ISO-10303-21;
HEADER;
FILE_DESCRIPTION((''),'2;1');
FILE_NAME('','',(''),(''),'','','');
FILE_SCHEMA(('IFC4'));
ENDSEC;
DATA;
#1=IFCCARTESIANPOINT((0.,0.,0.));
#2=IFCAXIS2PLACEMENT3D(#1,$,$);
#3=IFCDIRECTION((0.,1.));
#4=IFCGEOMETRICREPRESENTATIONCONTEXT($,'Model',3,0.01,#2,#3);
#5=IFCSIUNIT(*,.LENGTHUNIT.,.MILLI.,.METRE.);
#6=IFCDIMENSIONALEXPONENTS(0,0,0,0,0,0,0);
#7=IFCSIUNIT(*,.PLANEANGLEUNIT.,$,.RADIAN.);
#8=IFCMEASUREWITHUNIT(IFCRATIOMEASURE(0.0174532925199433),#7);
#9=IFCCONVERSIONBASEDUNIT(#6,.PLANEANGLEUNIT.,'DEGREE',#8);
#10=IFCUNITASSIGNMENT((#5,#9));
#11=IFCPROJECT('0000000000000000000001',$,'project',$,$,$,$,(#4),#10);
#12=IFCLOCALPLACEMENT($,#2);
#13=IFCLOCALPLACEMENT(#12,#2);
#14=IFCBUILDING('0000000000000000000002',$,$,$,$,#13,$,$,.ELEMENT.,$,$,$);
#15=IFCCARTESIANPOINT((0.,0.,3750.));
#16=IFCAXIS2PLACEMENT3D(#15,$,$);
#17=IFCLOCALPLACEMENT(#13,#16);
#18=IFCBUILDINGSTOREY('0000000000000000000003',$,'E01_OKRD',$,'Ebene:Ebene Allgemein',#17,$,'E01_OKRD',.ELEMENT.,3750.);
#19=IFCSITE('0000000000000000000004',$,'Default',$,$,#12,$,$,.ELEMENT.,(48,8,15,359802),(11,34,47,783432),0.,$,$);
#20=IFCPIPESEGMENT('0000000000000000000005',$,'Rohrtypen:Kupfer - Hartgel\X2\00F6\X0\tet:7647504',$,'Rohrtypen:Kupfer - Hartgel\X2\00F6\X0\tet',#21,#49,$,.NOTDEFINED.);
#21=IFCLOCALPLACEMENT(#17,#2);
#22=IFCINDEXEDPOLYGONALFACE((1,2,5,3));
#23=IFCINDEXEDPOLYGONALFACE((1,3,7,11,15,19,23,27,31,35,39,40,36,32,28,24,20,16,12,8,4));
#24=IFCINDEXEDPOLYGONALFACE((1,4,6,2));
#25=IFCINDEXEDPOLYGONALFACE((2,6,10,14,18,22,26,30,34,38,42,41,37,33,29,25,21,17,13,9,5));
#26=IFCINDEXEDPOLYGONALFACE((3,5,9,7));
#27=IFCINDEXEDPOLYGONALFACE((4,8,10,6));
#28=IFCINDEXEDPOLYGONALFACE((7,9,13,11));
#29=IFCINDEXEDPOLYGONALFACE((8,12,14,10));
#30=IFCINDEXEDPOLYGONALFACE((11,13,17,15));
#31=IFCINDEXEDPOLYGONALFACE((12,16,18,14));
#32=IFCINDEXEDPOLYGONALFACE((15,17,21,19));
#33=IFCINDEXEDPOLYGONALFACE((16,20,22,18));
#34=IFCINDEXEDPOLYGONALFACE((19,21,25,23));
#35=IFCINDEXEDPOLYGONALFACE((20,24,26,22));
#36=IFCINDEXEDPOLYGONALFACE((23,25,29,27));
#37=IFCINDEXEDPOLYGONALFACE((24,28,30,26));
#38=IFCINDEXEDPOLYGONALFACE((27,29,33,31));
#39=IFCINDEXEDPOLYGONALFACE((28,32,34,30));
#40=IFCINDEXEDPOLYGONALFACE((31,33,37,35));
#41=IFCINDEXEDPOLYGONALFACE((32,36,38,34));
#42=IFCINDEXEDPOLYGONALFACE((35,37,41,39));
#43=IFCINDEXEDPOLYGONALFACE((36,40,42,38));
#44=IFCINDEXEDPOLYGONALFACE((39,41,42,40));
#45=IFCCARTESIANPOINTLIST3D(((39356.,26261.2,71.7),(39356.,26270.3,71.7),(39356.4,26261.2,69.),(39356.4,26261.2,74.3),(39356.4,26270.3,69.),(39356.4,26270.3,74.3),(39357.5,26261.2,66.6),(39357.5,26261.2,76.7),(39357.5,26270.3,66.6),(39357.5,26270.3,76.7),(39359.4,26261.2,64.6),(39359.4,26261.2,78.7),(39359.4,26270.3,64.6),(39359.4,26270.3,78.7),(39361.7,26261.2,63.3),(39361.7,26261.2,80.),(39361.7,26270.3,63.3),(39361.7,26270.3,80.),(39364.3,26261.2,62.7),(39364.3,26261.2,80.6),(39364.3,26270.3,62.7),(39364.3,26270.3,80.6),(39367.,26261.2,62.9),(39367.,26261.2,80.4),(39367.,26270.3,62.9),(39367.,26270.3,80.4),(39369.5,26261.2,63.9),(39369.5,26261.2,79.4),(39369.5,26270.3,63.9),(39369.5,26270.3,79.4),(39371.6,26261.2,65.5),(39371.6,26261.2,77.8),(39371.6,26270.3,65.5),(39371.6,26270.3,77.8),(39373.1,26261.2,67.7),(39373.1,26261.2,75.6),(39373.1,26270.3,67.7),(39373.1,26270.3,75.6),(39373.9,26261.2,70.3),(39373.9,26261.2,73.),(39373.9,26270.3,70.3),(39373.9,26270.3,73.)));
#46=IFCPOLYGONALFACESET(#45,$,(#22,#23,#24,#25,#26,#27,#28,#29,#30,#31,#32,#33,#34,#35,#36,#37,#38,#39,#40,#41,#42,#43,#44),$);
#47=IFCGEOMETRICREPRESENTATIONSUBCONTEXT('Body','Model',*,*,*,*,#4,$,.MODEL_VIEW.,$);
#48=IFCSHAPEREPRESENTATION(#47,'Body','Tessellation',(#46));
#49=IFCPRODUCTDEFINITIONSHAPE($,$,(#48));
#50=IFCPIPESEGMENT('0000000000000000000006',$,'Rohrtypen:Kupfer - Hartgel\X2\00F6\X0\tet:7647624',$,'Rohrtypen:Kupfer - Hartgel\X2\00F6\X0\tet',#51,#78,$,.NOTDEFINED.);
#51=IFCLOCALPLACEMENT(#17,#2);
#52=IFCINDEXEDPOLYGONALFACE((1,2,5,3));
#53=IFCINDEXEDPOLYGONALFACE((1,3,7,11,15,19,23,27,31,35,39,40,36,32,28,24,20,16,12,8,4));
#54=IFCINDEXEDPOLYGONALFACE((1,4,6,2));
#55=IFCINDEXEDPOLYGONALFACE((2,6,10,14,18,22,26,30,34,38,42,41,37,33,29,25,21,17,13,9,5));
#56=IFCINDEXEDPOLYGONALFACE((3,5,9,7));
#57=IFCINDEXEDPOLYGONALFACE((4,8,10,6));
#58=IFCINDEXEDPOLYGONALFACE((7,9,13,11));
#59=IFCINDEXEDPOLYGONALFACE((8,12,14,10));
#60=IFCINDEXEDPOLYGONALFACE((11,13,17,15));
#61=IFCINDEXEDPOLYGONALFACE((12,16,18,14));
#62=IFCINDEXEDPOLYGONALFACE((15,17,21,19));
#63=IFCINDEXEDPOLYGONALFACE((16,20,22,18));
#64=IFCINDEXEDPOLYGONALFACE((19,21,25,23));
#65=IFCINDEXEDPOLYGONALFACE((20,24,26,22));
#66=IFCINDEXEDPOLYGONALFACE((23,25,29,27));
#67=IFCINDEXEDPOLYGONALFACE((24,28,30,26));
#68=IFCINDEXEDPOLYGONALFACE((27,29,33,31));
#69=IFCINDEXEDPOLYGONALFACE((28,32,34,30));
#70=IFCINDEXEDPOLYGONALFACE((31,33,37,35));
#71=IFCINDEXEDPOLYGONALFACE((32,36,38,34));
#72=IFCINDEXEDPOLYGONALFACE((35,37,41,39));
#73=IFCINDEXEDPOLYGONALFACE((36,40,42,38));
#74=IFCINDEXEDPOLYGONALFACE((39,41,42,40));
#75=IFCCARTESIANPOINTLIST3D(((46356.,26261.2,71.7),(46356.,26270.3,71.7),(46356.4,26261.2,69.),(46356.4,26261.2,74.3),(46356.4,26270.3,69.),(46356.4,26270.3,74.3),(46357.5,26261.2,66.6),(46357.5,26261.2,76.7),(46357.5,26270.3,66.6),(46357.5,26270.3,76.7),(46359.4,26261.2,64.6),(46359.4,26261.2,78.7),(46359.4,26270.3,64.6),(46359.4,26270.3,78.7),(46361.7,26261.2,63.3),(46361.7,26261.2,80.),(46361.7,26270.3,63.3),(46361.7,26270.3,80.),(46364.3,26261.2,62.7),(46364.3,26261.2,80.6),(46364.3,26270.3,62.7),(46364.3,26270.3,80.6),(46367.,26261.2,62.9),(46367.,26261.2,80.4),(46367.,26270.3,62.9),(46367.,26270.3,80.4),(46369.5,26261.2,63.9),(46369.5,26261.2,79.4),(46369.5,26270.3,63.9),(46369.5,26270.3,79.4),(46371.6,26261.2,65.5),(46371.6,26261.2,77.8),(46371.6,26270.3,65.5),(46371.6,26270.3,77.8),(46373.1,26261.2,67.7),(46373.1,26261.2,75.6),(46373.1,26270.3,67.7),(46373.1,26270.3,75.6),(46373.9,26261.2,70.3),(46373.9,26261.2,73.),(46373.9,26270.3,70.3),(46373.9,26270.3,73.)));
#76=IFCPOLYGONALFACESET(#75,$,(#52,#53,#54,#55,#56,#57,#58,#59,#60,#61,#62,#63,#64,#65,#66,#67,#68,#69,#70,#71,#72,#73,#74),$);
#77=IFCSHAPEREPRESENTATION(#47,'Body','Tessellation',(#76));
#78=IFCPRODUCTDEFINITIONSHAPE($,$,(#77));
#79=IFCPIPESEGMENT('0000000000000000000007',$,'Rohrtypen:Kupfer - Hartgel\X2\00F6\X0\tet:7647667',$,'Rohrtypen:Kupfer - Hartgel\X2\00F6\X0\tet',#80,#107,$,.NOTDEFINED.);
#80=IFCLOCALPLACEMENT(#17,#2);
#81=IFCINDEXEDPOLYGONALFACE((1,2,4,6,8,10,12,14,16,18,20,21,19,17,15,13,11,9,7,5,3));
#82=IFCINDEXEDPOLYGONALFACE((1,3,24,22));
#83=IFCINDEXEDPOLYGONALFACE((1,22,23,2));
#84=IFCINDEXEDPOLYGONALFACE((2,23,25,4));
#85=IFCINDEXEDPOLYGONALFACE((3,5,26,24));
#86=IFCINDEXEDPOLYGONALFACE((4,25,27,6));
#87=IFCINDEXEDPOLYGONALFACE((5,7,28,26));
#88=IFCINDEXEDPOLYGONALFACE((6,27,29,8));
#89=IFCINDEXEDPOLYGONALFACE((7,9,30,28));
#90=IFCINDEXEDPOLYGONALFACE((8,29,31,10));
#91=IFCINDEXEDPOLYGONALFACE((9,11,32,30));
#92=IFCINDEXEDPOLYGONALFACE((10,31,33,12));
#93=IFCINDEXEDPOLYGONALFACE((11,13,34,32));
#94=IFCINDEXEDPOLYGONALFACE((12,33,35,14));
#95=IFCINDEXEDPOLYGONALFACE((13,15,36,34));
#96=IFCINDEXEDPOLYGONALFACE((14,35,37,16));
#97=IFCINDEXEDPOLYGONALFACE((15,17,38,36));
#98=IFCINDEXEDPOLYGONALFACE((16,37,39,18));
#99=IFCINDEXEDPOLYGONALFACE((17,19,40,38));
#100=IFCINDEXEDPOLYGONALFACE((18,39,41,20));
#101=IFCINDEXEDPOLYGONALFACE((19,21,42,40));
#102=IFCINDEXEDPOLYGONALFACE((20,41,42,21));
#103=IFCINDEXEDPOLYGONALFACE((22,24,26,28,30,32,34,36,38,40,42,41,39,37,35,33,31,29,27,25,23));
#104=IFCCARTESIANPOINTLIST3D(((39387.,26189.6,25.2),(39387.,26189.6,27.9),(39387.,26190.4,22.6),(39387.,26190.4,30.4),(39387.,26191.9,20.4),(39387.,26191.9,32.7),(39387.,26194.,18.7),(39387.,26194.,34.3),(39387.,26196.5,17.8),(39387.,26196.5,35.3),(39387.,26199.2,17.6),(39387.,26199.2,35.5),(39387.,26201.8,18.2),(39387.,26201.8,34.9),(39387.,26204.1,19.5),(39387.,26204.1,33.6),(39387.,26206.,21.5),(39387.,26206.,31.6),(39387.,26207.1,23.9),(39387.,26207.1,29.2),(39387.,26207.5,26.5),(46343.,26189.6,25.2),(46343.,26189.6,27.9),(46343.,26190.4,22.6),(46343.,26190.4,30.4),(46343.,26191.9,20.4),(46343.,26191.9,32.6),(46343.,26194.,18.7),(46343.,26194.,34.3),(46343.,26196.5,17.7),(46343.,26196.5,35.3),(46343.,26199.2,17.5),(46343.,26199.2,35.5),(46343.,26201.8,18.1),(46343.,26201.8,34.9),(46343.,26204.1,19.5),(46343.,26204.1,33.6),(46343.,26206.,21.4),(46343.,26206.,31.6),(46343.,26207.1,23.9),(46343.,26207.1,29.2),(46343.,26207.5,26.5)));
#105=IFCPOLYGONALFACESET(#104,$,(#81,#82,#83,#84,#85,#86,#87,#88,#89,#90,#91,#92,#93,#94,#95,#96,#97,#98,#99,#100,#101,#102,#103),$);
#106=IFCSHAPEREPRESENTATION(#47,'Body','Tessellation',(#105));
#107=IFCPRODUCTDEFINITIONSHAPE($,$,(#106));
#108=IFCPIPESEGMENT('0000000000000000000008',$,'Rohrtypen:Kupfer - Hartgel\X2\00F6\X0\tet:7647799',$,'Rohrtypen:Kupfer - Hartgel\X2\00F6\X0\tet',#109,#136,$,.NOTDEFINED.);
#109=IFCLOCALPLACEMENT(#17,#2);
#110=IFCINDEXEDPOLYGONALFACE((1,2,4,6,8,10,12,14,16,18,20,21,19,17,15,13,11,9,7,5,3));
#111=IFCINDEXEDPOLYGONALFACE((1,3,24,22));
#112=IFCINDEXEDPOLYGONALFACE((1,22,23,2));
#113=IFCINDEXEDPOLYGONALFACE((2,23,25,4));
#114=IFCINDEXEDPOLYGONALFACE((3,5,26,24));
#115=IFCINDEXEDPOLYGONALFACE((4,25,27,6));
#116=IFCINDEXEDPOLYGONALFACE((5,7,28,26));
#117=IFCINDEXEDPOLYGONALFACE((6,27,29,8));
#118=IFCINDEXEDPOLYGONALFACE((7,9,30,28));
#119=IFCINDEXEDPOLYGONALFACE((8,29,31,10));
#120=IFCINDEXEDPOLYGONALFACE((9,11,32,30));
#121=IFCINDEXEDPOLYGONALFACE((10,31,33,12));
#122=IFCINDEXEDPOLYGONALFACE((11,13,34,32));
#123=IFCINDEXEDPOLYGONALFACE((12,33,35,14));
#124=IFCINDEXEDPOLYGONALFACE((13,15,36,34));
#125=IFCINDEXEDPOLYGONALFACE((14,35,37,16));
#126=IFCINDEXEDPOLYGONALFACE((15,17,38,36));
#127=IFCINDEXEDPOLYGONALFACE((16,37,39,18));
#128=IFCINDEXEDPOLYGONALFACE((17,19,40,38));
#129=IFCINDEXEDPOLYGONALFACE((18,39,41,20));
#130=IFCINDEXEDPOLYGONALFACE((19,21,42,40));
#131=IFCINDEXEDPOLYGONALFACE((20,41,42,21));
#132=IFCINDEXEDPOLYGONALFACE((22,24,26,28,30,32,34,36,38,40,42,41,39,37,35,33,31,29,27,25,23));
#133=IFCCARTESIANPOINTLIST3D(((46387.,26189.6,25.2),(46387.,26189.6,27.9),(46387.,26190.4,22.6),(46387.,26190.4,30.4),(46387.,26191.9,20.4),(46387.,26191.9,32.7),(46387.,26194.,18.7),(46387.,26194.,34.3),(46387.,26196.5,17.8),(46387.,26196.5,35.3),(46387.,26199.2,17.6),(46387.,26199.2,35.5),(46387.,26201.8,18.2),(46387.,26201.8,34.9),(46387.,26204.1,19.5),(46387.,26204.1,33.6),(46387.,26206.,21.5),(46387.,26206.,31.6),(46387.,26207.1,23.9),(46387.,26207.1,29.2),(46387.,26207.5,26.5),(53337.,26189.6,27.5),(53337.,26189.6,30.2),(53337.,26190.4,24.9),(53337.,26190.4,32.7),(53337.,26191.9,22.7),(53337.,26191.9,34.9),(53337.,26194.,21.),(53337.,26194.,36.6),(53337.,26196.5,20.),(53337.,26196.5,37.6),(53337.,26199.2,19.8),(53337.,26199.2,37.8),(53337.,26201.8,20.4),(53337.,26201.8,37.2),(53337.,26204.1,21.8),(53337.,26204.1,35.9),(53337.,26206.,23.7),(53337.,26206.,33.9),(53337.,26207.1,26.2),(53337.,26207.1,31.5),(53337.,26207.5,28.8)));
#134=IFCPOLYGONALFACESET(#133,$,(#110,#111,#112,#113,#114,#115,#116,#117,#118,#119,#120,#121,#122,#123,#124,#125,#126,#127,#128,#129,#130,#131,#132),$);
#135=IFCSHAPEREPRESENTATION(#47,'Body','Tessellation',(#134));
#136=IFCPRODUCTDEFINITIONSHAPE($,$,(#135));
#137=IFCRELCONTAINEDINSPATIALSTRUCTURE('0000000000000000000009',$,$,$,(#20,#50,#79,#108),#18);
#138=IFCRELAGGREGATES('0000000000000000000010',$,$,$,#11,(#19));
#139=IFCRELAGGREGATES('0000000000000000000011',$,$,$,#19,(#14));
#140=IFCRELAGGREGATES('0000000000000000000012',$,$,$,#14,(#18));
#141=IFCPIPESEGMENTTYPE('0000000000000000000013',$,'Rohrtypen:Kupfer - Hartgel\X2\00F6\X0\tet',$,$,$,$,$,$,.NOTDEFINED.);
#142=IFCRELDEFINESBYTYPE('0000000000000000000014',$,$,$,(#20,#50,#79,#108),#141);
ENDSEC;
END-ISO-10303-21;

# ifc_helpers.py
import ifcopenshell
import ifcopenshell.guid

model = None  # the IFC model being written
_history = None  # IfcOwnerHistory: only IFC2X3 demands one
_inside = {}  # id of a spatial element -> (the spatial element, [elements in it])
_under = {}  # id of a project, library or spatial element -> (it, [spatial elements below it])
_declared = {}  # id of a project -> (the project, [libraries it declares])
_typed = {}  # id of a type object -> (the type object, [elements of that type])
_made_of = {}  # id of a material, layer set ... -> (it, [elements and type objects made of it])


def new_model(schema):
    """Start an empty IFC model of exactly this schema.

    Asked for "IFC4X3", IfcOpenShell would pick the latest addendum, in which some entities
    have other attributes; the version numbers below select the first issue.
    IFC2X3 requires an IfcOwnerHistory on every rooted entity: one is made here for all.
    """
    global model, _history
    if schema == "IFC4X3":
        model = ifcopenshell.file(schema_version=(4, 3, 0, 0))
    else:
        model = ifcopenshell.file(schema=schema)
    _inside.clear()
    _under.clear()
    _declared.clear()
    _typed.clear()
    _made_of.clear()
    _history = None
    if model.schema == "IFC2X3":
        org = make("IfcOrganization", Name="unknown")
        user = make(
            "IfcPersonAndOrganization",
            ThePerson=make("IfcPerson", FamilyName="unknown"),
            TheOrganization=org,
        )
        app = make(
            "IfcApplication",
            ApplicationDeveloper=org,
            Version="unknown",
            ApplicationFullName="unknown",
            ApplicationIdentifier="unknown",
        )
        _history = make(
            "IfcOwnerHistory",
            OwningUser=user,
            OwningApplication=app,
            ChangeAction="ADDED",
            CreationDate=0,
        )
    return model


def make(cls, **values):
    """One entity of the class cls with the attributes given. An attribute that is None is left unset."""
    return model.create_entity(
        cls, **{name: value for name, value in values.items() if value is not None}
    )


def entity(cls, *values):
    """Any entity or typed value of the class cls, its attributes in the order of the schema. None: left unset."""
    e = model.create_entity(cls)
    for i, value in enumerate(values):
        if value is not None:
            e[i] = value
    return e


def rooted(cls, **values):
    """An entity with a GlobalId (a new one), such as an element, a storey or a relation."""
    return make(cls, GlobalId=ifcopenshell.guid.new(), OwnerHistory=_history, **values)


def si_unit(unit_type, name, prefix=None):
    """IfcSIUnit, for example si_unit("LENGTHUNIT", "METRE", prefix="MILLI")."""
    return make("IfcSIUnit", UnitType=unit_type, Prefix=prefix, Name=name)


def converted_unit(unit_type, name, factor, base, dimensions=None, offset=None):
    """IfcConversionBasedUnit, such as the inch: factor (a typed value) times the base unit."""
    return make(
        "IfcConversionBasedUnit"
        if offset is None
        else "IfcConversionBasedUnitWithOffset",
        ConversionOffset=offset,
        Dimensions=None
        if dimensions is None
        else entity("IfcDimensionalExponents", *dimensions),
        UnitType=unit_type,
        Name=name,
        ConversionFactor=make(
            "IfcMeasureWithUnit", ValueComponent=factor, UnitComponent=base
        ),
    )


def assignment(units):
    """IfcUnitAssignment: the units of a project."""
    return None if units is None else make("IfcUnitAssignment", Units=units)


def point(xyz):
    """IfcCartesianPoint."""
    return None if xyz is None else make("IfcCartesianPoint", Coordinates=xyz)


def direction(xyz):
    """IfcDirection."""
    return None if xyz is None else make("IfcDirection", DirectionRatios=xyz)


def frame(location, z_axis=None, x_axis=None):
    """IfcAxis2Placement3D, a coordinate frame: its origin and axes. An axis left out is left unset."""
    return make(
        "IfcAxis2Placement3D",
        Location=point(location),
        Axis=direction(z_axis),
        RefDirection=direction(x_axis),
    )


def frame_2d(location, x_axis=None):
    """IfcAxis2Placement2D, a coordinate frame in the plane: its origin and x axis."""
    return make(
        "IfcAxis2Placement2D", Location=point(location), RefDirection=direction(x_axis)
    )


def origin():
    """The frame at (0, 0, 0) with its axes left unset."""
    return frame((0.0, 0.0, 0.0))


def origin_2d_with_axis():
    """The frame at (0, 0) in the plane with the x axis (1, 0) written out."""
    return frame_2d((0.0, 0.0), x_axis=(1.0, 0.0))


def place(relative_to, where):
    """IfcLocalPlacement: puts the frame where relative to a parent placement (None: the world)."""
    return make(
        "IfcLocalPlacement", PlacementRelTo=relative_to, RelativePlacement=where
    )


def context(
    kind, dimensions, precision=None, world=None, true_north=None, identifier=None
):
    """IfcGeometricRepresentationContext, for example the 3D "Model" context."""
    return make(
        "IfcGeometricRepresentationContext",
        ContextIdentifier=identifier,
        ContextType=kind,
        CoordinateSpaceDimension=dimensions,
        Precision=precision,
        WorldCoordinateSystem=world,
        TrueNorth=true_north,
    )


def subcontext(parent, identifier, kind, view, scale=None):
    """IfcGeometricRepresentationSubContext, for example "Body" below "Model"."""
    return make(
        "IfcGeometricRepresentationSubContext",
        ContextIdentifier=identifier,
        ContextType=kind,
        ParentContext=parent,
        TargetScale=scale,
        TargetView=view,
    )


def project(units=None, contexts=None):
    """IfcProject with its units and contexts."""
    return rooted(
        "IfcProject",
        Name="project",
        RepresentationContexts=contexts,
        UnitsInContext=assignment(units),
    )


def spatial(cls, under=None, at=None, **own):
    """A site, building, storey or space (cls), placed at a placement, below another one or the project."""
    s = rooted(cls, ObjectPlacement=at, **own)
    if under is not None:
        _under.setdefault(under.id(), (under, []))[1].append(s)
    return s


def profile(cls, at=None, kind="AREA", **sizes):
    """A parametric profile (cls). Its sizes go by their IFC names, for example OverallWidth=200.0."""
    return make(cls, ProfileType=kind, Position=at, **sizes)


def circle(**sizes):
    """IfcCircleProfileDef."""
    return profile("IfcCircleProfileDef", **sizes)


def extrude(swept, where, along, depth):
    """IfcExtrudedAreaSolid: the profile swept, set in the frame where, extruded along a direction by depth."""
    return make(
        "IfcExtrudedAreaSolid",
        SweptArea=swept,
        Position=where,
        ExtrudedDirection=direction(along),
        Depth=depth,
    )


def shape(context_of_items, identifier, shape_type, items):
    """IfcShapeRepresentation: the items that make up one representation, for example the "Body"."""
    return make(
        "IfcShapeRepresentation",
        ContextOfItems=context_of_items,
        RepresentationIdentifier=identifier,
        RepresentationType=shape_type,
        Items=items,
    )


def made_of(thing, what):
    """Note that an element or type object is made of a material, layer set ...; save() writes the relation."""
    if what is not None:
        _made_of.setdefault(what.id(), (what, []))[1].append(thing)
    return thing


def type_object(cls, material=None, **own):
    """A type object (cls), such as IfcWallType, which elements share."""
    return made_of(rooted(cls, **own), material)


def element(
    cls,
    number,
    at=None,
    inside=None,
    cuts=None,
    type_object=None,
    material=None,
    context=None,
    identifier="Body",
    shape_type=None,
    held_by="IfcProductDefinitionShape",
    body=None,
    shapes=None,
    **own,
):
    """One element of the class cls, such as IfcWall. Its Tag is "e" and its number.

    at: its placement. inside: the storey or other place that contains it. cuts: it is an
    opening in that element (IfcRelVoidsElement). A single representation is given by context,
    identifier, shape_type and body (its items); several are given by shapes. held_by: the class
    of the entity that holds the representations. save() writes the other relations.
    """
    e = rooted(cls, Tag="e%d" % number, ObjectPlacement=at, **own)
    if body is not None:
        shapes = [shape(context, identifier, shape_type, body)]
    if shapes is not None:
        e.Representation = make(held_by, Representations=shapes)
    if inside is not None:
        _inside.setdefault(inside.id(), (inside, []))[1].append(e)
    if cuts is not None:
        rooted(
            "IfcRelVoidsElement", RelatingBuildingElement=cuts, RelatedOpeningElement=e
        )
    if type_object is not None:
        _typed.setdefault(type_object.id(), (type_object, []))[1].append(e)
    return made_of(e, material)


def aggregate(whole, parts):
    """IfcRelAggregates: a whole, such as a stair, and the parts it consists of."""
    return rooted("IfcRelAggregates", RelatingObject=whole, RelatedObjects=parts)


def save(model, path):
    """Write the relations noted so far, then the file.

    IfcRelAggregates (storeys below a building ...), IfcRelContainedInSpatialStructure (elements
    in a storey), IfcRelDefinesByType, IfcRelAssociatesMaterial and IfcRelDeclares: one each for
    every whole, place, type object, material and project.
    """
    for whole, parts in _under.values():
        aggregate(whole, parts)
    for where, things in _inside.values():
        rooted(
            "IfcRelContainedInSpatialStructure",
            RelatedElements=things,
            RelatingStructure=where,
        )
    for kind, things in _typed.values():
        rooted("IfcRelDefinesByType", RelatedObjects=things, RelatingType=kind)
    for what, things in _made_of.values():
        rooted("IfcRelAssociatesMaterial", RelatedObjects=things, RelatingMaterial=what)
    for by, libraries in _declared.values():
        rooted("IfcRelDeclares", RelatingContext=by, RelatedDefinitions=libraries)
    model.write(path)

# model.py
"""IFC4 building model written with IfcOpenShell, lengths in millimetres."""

from ifc_helpers import new_model, entity, si_unit, converted_unit, direction, frame, frame_2d, origin, origin_2d_with_axis, place, context, subcontext, project, spatial, circle, extrude, type_object, element, save


model = new_model("IFC4")

# Units and contexts
model_context = context("Model", 3, precision=0.01, world=origin(), true_north=direction((0.0, 1.0)))
body_context = subcontext(model_context, "Body", "Model", "MODEL_VIEW")
ifc_project = project(units=[si_unit("LENGTHUNIT", "METRE", prefix="MILLI"), converted_unit("PLANEANGLEUNIT", "DEGREE", entity("IfcRatioMeasure", 0.0174532925199433), si_unit("PLANEANGLEUNIT", "RADIAN"), dimensions=[0, 0, 0, 0, 0, 0, 0])], contexts=[model_context])

# Site, building, storey
site_placement = place(None, origin())
site = spatial("IfcSite", under=ifc_project, at=site_placement, Name="Default", CompositionType="ELEMENT", RefLatitude=(48, 8, 15, 359802), RefLongitude=(11, 34, 47, 783432), RefElevation=0.0)
building_placement = place(site_placement, origin())
building = spatial("IfcBuilding", under=site, at=building_placement, CompositionType="ELEMENT")
storey_placement = place(building_placement, frame((0.0, 0.0, 3750.0)))
storey = spatial("IfcBuildingStorey", under=building, at=storey_placement, Name="E01_OKRD", ObjectType="Ebene:Ebene Allgemein", LongName="E01_OKRD", CompositionType="ELEMENT", Elevation=3750.0)

# Pipe segments
pipe_segment_type = type_object("IfcPipeSegmentType", Name="Rohrtypen:Kupfer - Hartgelötet", PredefinedType="NOTDEFINED")
pipe_segment_1_placement = place(storey_placement, frame((39354.4, 26261.2, 61.1)))
element("IfcPipeSegment", 1, at=pipe_segment_1_placement, inside=storey, type_object=pipe_segment_type, Name="Rohrtypen:Kupfer - Hartgelötet:7647504", ObjectType="Rohrtypen:Kupfer - Hartgelötet", PredefinedType="NOTDEFINED", context=body_context, shape_type="SweptSolid", body=[
    extrude(circle(Radius=9.0, at=frame_2d((0.0, 0.0), x_axis=(1.0, 0.0))), frame((10.6, 9.1, 10.6), z_axis=(0.000126, -1.0, -0.000366), x_axis=(-1.0, -0.000126, 0.0)), (0.0, 0.0, 1.0), 9.1),
])
pipe_segment_2_placement = place(storey_placement, frame((46354.4, 26261.2, 61.1)))
element("IfcPipeSegment", 2, at=pipe_segment_2_placement, inside=storey, type_object=pipe_segment_type, Name="Rohrtypen:Kupfer - Hartgelötet:7647624", ObjectType="Rohrtypen:Kupfer - Hartgelötet", PredefinedType="NOTDEFINED", context=body_context, shape_type="SweptSolid", body=[
    extrude(circle(Radius=9.0, at=origin_2d_with_axis()), frame((10.6, 9.1, 10.6), z_axis=(0.000126, -1.0, -0.000366), x_axis=(-1.0, -0.000126, 0.0)), (0.0, 0.0, 1.0), 9.1),
])
pipe_segment_3_placement = place(storey_placement, frame((39387.0, 26187.9, 15.9)))
element("IfcPipeSegment", 3, at=pipe_segment_3_placement, inside=storey, type_object=pipe_segment_type, Name="Rohrtypen:Kupfer - Hartgelötet:7647667", ObjectType="Rohrtypen:Kupfer - Hartgelötet", PredefinedType="NOTDEFINED", context=body_context, shape_type="SweptSolid", body=[
    extrude(circle(Radius=9.0, at=origin_2d_with_axis()), frame((0.0, 10.6, 10.6), z_axis=(1.0, 0.0, -0.000002), x_axis=(0.0, 1.0, 0.0)), (0.0, 0.0, 1.0), 6956.0),
])
pipe_segment_4_placement = place(storey_placement, frame((46387.0, 26187.9, 15.9)))
element("IfcPipeSegment", 4, at=pipe_segment_4_placement, inside=storey, type_object=pipe_segment_type, Name="Rohrtypen:Kupfer - Hartgelötet:7647799", ObjectType="Rohrtypen:Kupfer - Hartgelötet", PredefinedType="NOTDEFINED", context=body_context, shape_type="SweptSolid", body=[
    extrude(circle(Radius=9.0, at=origin_2d_with_axis()), frame((0.0, 10.6, 10.6), z_axis=(1.0, 0.0, 0.000329), x_axis=(0.0, 1.0, 0.0)), (0.0, 0.0, 1.0), 6950.0),
])

save(model, "model.ifc")
